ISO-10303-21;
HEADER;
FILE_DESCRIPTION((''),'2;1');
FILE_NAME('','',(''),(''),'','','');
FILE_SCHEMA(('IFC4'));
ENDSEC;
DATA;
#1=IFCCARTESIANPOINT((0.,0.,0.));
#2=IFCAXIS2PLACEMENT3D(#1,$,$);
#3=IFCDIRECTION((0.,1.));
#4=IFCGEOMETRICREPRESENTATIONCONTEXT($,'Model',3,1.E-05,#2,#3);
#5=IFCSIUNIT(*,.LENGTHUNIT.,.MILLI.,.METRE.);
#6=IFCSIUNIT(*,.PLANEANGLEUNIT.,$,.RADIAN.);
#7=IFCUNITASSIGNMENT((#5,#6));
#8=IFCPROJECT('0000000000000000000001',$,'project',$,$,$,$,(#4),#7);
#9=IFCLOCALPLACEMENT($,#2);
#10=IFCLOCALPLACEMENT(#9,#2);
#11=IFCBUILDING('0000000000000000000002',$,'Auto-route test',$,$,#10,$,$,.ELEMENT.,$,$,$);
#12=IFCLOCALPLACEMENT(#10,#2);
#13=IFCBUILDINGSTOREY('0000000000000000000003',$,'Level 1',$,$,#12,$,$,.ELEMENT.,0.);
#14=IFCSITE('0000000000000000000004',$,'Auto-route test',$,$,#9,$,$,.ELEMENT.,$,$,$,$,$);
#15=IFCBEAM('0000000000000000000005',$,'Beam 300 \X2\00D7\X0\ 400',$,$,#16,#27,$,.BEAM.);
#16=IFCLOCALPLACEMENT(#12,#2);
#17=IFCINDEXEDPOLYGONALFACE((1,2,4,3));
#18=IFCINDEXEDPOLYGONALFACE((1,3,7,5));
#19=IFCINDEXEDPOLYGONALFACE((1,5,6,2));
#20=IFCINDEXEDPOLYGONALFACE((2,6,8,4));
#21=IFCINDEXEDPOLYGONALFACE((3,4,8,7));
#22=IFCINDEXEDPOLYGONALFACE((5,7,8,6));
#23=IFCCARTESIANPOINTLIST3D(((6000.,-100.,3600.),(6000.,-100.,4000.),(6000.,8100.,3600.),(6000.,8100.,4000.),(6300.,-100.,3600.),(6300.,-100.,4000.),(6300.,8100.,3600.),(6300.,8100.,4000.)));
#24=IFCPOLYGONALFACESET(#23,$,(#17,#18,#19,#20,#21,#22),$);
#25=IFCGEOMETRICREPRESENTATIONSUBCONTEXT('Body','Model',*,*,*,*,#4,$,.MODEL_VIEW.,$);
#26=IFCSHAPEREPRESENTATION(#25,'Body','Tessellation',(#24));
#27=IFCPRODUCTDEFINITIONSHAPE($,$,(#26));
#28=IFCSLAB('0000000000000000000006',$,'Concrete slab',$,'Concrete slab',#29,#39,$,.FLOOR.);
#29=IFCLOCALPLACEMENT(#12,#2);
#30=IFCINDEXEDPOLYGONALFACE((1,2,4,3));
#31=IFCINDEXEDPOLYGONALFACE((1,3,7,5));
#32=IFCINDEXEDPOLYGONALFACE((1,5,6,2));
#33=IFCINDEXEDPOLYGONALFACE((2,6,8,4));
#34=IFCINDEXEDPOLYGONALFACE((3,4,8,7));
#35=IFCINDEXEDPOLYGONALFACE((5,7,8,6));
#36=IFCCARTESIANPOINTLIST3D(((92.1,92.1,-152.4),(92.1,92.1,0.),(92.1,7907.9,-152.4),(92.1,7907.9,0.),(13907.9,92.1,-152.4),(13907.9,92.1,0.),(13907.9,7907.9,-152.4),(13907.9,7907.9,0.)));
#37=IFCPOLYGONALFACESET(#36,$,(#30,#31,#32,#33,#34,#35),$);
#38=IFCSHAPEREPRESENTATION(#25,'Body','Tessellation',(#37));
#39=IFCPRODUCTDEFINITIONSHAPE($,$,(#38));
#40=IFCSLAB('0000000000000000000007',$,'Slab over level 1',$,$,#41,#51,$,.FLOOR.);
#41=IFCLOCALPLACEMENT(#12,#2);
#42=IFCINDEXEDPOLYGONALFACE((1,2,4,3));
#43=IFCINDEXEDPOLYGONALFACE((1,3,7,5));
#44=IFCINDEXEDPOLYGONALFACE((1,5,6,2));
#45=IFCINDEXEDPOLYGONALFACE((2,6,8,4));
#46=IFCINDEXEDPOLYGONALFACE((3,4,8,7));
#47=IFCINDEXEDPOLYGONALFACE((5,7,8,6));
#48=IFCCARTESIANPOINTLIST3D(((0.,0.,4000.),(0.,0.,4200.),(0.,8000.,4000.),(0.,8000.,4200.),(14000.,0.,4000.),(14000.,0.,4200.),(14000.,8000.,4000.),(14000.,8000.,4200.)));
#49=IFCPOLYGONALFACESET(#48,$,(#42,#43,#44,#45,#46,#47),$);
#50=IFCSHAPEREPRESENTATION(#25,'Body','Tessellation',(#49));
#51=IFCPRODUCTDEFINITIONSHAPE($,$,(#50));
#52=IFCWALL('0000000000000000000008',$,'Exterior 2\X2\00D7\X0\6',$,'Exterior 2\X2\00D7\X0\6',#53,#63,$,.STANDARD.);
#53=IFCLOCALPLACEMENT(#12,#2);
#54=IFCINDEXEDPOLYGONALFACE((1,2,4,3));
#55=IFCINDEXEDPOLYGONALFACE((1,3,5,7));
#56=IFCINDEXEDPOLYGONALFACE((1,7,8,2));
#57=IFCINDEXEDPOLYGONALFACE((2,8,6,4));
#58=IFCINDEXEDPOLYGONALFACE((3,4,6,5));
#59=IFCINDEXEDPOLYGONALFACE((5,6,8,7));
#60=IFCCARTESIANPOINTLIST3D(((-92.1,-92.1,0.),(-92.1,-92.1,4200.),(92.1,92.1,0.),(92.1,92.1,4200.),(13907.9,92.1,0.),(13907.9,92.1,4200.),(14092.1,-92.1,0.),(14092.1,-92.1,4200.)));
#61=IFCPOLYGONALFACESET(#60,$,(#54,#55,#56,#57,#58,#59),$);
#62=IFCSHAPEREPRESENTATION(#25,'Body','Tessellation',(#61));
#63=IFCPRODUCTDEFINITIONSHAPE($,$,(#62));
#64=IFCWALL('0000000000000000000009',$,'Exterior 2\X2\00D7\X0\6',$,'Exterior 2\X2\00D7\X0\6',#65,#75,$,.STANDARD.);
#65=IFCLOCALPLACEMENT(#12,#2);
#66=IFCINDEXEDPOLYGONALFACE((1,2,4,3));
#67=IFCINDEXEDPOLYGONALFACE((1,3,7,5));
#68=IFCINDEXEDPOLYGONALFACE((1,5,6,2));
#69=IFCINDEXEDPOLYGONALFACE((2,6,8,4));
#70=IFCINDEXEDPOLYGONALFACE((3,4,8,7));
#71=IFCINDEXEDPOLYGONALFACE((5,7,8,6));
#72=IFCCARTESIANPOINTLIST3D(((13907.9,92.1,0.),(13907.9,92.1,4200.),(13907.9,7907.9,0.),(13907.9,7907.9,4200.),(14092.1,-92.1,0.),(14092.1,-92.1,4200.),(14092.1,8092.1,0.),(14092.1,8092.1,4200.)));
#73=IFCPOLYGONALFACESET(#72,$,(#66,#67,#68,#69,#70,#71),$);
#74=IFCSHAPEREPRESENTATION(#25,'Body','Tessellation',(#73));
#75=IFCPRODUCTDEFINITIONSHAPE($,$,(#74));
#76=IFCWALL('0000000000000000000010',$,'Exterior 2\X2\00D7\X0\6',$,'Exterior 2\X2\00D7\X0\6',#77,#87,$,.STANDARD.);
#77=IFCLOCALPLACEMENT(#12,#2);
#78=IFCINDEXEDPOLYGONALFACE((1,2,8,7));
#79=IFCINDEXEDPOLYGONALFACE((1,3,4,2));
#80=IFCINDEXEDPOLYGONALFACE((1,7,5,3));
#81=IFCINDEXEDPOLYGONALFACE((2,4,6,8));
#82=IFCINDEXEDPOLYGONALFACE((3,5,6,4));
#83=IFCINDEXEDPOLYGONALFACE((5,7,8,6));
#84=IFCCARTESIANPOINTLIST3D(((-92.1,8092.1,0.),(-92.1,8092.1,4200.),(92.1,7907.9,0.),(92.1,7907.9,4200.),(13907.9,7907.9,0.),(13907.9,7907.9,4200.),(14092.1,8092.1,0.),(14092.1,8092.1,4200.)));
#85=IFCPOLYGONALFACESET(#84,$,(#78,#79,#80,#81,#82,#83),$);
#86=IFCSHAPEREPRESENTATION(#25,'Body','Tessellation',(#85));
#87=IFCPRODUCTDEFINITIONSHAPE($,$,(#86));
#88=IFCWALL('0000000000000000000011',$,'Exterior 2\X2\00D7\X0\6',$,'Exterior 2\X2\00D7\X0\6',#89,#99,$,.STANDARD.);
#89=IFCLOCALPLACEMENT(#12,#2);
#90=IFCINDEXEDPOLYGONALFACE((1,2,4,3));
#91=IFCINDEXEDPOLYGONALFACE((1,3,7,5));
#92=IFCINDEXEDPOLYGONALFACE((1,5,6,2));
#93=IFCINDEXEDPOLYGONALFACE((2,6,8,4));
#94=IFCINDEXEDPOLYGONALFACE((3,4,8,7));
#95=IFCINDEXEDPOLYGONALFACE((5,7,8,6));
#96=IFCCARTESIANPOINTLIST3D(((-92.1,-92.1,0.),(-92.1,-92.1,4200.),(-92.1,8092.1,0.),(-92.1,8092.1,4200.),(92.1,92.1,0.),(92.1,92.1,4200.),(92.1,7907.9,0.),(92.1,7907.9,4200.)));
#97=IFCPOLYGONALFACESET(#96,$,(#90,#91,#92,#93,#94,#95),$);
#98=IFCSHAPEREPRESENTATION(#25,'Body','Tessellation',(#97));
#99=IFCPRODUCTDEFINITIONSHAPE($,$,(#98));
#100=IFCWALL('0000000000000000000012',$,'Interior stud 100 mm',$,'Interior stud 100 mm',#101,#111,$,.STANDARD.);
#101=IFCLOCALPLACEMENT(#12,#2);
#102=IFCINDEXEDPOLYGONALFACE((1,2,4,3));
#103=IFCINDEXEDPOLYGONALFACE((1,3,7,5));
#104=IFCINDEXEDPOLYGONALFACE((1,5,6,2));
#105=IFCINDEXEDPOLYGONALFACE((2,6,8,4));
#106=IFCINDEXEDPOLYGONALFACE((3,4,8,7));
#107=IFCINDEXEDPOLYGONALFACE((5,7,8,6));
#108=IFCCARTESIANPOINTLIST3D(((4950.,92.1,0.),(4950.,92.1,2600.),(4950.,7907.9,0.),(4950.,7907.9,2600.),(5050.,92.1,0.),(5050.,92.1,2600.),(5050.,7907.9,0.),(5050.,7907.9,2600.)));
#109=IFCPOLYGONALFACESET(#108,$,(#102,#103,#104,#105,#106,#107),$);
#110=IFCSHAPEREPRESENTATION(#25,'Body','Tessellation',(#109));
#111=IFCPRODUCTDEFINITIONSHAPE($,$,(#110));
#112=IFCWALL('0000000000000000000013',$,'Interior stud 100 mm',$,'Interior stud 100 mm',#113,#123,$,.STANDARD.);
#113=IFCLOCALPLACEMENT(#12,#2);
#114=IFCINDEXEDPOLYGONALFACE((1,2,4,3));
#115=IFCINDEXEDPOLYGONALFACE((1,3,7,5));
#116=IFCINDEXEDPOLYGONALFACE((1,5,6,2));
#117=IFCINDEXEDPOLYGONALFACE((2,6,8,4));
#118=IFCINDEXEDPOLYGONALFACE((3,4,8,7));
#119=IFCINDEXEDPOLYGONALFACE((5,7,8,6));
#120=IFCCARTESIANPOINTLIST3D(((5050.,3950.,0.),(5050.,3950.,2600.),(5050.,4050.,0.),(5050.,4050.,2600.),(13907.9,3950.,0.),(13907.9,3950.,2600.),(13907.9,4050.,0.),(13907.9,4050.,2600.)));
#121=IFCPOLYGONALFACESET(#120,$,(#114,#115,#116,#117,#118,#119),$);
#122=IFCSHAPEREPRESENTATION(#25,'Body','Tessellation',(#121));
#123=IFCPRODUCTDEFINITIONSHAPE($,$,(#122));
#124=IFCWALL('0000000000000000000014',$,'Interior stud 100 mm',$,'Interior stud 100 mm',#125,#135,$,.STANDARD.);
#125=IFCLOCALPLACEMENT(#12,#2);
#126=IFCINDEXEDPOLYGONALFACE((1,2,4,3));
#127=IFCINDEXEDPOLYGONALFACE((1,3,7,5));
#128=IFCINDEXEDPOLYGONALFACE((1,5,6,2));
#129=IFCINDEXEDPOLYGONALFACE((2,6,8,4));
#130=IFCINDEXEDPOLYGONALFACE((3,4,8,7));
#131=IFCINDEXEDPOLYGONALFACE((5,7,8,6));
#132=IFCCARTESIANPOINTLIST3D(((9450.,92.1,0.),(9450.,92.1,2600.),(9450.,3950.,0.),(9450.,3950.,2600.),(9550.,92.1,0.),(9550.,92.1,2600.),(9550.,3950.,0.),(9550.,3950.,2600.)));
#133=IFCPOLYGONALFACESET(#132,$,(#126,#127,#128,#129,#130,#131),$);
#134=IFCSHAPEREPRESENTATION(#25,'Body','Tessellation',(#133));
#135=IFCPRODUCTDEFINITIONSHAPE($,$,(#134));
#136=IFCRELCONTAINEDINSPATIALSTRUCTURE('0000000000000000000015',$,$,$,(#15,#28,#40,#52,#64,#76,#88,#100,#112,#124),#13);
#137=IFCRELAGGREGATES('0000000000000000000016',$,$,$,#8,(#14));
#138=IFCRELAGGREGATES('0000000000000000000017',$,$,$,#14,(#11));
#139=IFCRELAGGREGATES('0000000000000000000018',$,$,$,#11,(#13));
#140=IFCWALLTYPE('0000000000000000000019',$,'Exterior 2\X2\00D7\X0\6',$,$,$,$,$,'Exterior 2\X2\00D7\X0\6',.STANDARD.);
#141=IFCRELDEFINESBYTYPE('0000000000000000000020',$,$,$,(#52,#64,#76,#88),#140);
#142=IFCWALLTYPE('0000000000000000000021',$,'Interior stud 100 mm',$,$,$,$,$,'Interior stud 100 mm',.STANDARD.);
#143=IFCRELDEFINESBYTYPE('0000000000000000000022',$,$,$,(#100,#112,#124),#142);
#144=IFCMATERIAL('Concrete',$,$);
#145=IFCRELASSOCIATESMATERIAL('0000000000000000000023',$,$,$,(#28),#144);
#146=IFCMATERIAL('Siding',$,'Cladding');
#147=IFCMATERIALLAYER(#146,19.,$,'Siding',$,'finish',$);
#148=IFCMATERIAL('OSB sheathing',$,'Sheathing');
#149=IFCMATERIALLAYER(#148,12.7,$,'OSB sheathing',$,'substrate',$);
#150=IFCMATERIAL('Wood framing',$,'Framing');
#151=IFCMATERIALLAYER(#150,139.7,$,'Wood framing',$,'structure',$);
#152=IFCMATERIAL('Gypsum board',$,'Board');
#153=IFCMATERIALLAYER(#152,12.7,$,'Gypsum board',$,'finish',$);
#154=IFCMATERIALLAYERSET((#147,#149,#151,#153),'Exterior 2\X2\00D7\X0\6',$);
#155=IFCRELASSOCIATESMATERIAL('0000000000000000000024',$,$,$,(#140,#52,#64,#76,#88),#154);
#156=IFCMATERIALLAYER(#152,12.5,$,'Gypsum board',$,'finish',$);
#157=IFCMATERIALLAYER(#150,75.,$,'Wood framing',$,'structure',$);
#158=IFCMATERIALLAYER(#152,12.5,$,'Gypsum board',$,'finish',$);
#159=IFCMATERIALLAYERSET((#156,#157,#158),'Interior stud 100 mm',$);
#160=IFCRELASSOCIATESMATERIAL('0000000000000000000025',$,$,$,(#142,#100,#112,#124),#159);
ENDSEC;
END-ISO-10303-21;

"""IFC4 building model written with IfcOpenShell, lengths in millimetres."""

from ifc_helpers import new_model, si_unit, direction, frame, origin, origin_with_axes, place, context, subcontext, project, spatial, polyline, outline, extrude, material, layer, layer_set, layer_usage, type_object, element, save


model = new_model("IFC4")

# Units and contexts
model_context = context("Model", 3, precision=1e-05, world=origin(), true_north=direction((0.0, 1.0)))
body_context = subcontext(model_context, "Body", "Model", "MODEL_VIEW")
ifc_project = project(units=[si_unit("LENGTHUNIT", "METRE", prefix="MILLI"), si_unit("PLANEANGLEUNIT", "RADIAN")], contexts=[model_context])

# Site, building, storey
site_placement = place(None, origin())
site = spatial("IfcSite", under=ifc_project, at=site_placement, Name="Auto-route test", CompositionType="ELEMENT")
building_placement = place(site_placement, origin())
building = spatial("IfcBuilding", under=site, at=building_placement, Name="Auto-route test", CompositionType="ELEMENT")
storey_placement = place(building_placement, origin())
storey = spatial("IfcBuildingStorey", under=building, at=storey_placement, Name="Level 1", CompositionType="ELEMENT", Elevation=0.0)

# Beam
beam_placement = place(storey_placement, origin_with_axes())
element("IfcBeam", 1, at=beam_placement, inside=storey, Name="Beam 300 × 400", PredefinedType="BEAM", context=body_context, shape_type="SweptSolid", body=[
    extrude(outline(polyline([(6000.0, -100.0), (6300.0, -100.0), (6300.0, 8100.0), (6000.0, 8100.0), (6000.0, -100.0)])), frame((0.0, 0.0, 3600.0)), (0.0, 0.0, 1.0), 400.0),
])

# Slabs
ifc_material_1 = material(Name="Concrete")
slab_1_placement = place(storey_placement, origin_with_axes())
element("IfcSlab", 2, at=slab_1_placement, inside=storey, material=ifc_material_1, Name="Concrete slab", ObjectType="Concrete slab", PredefinedType="FLOOR", context=body_context, shape_type="SweptSolid", body=[
    extrude(outline(polyline([(92.1, 92.1), (13907.9, 92.1), (13907.9, 7907.9), (92.1, 7907.9), (92.1, 92.1)])), frame((0.0, 0.0, -152.4)), (0.0, 0.0, 1.0), 152.4),
])
slab_2_placement = place(storey_placement, origin_with_axes())
element("IfcSlab", 3, at=slab_2_placement, inside=storey, Name="Slab over level 1", PredefinedType="FLOOR", context=body_context, shape_type="SweptSolid", body=[
    extrude(outline(polyline([(0.0, 0.0), (14000.0, 0.0), (14000.0, 8000.0), (0.0, 8000.0), (0.0, 0.0)])), frame((0.0, 0.0, 4000.0)), (0.0, 0.0, 1.0), 200.0),
])

# Walls
ifc_material_2 = material(Name="Siding", Category="Cladding")
ifc_layer_1 = layer(ifc_material_2, 19.0, Name="Siding", Category="finish")
ifc_material_3 = material(Name="OSB sheathing", Category="Sheathing")
ifc_layer_2 = layer(ifc_material_3, 12.7, Name="OSB sheathing", Category="substrate")
ifc_material_4 = material(Name="Wood framing", Category="Framing")
ifc_layer_3 = layer(ifc_material_4, 139.7, Name="Wood framing", Category="structure")
ifc_material_5 = material(Name="Gypsum board", Category="Board")
ifc_layer_4 = layer(ifc_material_5, 12.7, Name="Gypsum board", Category="finish")
ifc_layer_set_1 = layer_set([ifc_layer_1, ifc_layer_2, ifc_layer_3, ifc_layer_4], Name="Exterior 2×6")
ifc_layer_usage_1 = layer_usage(ifc_layer_set_1, "AXIS2", "NEGATIVE", 92.1)
wall_type_1 = type_object("IfcWallType", Name="Exterior 2×6", ElementType="Exterior 2×6", PredefinedType="STANDARD", material=ifc_layer_set_1)
wall_1_placement = place(storey_placement, origin_with_axes())
element("IfcWall", 4, at=wall_1_placement, inside=storey, type_object=wall_type_1, material=ifc_layer_usage_1, Name="Exterior 2×6", ObjectType="Exterior 2×6", PredefinedType="STANDARD", context=body_context, shape_type="SweptSolid", body=[
    extrude(outline(polyline([(-92.1, -92.1), (14092.1, -92.1), (13907.9, 92.1), (92.1, 92.1), (-92.1, -92.1)])), origin(), (0.0, 0.0, 1.0), 4200.0),
])
ifc_layer_usage_2 = layer_usage(ifc_layer_set_1, "AXIS2", "NEGATIVE", 92.1)
wall_2_placement = place(storey_placement, frame((14000.0, 0.0, 0.0), z_axis=(0.0, 0.0, 1.0), x_axis=(0.0, 1.0, 0.0)))
element("IfcWall", 5, at=wall_2_placement, inside=storey, type_object=wall_type_1, material=ifc_layer_usage_2, Name="Exterior 2×6", ObjectType="Exterior 2×6", PredefinedType="STANDARD", context=body_context, shape_type="SweptSolid", body=[
    extrude(outline(polyline([(-92.1, -92.1), (8092.1, -92.1), (7907.9, 92.1), (92.1, 92.1), (-92.1, -92.1)])), origin(), (0.0, 0.0, 1.0), 4200.0),
])
ifc_layer_usage_3 = layer_usage(ifc_layer_set_1, "AXIS2", "NEGATIVE", 92.1)
wall_3_placement = place(storey_placement, frame((14000.0, 8000.0, 0.0), z_axis=(0.0, 0.0, 1.0), x_axis=(-1.0, 0.0, 0.0)))
element("IfcWall", 6, at=wall_3_placement, inside=storey, type_object=wall_type_1, material=ifc_layer_usage_3, Name="Exterior 2×6", ObjectType="Exterior 2×6", PredefinedType="STANDARD", context=body_context, shape_type="SweptSolid", body=[
    extrude(outline(polyline([(-92.1, -92.1), (14092.1, -92.1), (13907.9, 92.1), (92.1, 92.1), (-92.1, -92.1)])), origin(), (0.0, 0.0, 1.0), 4200.0),
])
ifc_layer_usage_4 = layer_usage(ifc_layer_set_1, "AXIS2", "NEGATIVE", 92.1)
wall_4_placement = place(storey_placement, frame((0.0, 8000.0, 0.0), z_axis=(0.0, 0.0, 1.0), x_axis=(0.0, -1.0, 0.0)))
element("IfcWall", 7, at=wall_4_placement, inside=storey, type_object=wall_type_1, material=ifc_layer_usage_4, Name="Exterior 2×6", ObjectType="Exterior 2×6", PredefinedType="STANDARD", context=body_context, shape_type="SweptSolid", body=[
    extrude(outline(polyline([(-92.1, -92.1), (8092.1, -92.1), (7907.9, 92.1), (92.1, 92.1), (-92.1, -92.1)])), origin(), (0.0, 0.0, 1.0), 4200.0),
])
ifc_layer_5 = layer(ifc_material_5, 12.5, Name="Gypsum board", Category="finish")
ifc_layer_6 = layer(ifc_material_4, 75.0, Name="Wood framing", Category="structure")
ifc_layer_7 = layer(ifc_material_5, 12.5, Name="Gypsum board", Category="finish")
ifc_layer_set_2 = layer_set([ifc_layer_5, ifc_layer_6, ifc_layer_7], Name="Interior stud 100 mm")
ifc_layer_usage_5 = layer_usage(ifc_layer_set_2, "AXIS2", "NEGATIVE", 50.0)
wall_type_2 = type_object("IfcWallType", Name="Interior stud 100 mm", ElementType="Interior stud 100 mm", PredefinedType="STANDARD", material=ifc_layer_set_2)
wall_5_placement = place(storey_placement, frame((5000.0, 0.0, 0.0), z_axis=(0.0, 0.0, 1.0), x_axis=(0.0, 1.0, 0.0)))
element("IfcWall", 8, at=wall_5_placement, inside=storey, type_object=wall_type_2, material=ifc_layer_usage_5, Name="Interior stud 100 mm", ObjectType="Interior stud 100 mm", PredefinedType="STANDARD", context=body_context, shape_type="SweptSolid", body=[
    extrude(outline(polyline([(92.1, -50.0), (7907.9, -50.0), (7907.9, 50.0), (92.1, 50.0), (92.1, -50.0)])), origin(), (0.0, 0.0, 1.0), 2600.0),
])
ifc_layer_usage_6 = layer_usage(ifc_layer_set_2, "AXIS2", "NEGATIVE", 50.0)
wall_6_placement = place(storey_placement, frame((5000.0, 4000.0, 0.0), z_axis=(0.0, 0.0, 1.0), x_axis=(1.0, 0.0, 0.0)))
element("IfcWall", 9, at=wall_6_placement, inside=storey, type_object=wall_type_2, material=ifc_layer_usage_6, Name="Interior stud 100 mm", ObjectType="Interior stud 100 mm", PredefinedType="STANDARD", context=body_context, shape_type="SweptSolid", body=[
    extrude(outline(polyline([(50.0, -50.0), (8907.9, -50.0), (8907.9, 50.0), (50.0, 50.0), (50.0, -50.0)])), origin(), (0.0, 0.0, 1.0), 2600.0),
])
ifc_layer_usage_7 = layer_usage(ifc_layer_set_2, "AXIS2", "NEGATIVE", 50.0)
wall_7_placement = place(storey_placement, frame((9500.0, 0.0, 0.0), z_axis=(0.0, 0.0, 1.0), x_axis=(0.0, 1.0, 0.0)))
element("IfcWall", 10, at=wall_7_placement, inside=storey, type_object=wall_type_2, material=ifc_layer_usage_7, Name="Interior stud 100 mm", ObjectType="Interior stud 100 mm", PredefinedType="STANDARD", context=body_context, shape_type="SweptSolid", body=[
    extrude(outline(polyline([(92.1, -50.0), (3950.0, -50.0), (3950.0, 50.0), (92.1, 50.0), (92.1, -50.0)])), origin(), (0.0, 0.0, 1.0), 2600.0),
])

save(model, "model.ifc")
